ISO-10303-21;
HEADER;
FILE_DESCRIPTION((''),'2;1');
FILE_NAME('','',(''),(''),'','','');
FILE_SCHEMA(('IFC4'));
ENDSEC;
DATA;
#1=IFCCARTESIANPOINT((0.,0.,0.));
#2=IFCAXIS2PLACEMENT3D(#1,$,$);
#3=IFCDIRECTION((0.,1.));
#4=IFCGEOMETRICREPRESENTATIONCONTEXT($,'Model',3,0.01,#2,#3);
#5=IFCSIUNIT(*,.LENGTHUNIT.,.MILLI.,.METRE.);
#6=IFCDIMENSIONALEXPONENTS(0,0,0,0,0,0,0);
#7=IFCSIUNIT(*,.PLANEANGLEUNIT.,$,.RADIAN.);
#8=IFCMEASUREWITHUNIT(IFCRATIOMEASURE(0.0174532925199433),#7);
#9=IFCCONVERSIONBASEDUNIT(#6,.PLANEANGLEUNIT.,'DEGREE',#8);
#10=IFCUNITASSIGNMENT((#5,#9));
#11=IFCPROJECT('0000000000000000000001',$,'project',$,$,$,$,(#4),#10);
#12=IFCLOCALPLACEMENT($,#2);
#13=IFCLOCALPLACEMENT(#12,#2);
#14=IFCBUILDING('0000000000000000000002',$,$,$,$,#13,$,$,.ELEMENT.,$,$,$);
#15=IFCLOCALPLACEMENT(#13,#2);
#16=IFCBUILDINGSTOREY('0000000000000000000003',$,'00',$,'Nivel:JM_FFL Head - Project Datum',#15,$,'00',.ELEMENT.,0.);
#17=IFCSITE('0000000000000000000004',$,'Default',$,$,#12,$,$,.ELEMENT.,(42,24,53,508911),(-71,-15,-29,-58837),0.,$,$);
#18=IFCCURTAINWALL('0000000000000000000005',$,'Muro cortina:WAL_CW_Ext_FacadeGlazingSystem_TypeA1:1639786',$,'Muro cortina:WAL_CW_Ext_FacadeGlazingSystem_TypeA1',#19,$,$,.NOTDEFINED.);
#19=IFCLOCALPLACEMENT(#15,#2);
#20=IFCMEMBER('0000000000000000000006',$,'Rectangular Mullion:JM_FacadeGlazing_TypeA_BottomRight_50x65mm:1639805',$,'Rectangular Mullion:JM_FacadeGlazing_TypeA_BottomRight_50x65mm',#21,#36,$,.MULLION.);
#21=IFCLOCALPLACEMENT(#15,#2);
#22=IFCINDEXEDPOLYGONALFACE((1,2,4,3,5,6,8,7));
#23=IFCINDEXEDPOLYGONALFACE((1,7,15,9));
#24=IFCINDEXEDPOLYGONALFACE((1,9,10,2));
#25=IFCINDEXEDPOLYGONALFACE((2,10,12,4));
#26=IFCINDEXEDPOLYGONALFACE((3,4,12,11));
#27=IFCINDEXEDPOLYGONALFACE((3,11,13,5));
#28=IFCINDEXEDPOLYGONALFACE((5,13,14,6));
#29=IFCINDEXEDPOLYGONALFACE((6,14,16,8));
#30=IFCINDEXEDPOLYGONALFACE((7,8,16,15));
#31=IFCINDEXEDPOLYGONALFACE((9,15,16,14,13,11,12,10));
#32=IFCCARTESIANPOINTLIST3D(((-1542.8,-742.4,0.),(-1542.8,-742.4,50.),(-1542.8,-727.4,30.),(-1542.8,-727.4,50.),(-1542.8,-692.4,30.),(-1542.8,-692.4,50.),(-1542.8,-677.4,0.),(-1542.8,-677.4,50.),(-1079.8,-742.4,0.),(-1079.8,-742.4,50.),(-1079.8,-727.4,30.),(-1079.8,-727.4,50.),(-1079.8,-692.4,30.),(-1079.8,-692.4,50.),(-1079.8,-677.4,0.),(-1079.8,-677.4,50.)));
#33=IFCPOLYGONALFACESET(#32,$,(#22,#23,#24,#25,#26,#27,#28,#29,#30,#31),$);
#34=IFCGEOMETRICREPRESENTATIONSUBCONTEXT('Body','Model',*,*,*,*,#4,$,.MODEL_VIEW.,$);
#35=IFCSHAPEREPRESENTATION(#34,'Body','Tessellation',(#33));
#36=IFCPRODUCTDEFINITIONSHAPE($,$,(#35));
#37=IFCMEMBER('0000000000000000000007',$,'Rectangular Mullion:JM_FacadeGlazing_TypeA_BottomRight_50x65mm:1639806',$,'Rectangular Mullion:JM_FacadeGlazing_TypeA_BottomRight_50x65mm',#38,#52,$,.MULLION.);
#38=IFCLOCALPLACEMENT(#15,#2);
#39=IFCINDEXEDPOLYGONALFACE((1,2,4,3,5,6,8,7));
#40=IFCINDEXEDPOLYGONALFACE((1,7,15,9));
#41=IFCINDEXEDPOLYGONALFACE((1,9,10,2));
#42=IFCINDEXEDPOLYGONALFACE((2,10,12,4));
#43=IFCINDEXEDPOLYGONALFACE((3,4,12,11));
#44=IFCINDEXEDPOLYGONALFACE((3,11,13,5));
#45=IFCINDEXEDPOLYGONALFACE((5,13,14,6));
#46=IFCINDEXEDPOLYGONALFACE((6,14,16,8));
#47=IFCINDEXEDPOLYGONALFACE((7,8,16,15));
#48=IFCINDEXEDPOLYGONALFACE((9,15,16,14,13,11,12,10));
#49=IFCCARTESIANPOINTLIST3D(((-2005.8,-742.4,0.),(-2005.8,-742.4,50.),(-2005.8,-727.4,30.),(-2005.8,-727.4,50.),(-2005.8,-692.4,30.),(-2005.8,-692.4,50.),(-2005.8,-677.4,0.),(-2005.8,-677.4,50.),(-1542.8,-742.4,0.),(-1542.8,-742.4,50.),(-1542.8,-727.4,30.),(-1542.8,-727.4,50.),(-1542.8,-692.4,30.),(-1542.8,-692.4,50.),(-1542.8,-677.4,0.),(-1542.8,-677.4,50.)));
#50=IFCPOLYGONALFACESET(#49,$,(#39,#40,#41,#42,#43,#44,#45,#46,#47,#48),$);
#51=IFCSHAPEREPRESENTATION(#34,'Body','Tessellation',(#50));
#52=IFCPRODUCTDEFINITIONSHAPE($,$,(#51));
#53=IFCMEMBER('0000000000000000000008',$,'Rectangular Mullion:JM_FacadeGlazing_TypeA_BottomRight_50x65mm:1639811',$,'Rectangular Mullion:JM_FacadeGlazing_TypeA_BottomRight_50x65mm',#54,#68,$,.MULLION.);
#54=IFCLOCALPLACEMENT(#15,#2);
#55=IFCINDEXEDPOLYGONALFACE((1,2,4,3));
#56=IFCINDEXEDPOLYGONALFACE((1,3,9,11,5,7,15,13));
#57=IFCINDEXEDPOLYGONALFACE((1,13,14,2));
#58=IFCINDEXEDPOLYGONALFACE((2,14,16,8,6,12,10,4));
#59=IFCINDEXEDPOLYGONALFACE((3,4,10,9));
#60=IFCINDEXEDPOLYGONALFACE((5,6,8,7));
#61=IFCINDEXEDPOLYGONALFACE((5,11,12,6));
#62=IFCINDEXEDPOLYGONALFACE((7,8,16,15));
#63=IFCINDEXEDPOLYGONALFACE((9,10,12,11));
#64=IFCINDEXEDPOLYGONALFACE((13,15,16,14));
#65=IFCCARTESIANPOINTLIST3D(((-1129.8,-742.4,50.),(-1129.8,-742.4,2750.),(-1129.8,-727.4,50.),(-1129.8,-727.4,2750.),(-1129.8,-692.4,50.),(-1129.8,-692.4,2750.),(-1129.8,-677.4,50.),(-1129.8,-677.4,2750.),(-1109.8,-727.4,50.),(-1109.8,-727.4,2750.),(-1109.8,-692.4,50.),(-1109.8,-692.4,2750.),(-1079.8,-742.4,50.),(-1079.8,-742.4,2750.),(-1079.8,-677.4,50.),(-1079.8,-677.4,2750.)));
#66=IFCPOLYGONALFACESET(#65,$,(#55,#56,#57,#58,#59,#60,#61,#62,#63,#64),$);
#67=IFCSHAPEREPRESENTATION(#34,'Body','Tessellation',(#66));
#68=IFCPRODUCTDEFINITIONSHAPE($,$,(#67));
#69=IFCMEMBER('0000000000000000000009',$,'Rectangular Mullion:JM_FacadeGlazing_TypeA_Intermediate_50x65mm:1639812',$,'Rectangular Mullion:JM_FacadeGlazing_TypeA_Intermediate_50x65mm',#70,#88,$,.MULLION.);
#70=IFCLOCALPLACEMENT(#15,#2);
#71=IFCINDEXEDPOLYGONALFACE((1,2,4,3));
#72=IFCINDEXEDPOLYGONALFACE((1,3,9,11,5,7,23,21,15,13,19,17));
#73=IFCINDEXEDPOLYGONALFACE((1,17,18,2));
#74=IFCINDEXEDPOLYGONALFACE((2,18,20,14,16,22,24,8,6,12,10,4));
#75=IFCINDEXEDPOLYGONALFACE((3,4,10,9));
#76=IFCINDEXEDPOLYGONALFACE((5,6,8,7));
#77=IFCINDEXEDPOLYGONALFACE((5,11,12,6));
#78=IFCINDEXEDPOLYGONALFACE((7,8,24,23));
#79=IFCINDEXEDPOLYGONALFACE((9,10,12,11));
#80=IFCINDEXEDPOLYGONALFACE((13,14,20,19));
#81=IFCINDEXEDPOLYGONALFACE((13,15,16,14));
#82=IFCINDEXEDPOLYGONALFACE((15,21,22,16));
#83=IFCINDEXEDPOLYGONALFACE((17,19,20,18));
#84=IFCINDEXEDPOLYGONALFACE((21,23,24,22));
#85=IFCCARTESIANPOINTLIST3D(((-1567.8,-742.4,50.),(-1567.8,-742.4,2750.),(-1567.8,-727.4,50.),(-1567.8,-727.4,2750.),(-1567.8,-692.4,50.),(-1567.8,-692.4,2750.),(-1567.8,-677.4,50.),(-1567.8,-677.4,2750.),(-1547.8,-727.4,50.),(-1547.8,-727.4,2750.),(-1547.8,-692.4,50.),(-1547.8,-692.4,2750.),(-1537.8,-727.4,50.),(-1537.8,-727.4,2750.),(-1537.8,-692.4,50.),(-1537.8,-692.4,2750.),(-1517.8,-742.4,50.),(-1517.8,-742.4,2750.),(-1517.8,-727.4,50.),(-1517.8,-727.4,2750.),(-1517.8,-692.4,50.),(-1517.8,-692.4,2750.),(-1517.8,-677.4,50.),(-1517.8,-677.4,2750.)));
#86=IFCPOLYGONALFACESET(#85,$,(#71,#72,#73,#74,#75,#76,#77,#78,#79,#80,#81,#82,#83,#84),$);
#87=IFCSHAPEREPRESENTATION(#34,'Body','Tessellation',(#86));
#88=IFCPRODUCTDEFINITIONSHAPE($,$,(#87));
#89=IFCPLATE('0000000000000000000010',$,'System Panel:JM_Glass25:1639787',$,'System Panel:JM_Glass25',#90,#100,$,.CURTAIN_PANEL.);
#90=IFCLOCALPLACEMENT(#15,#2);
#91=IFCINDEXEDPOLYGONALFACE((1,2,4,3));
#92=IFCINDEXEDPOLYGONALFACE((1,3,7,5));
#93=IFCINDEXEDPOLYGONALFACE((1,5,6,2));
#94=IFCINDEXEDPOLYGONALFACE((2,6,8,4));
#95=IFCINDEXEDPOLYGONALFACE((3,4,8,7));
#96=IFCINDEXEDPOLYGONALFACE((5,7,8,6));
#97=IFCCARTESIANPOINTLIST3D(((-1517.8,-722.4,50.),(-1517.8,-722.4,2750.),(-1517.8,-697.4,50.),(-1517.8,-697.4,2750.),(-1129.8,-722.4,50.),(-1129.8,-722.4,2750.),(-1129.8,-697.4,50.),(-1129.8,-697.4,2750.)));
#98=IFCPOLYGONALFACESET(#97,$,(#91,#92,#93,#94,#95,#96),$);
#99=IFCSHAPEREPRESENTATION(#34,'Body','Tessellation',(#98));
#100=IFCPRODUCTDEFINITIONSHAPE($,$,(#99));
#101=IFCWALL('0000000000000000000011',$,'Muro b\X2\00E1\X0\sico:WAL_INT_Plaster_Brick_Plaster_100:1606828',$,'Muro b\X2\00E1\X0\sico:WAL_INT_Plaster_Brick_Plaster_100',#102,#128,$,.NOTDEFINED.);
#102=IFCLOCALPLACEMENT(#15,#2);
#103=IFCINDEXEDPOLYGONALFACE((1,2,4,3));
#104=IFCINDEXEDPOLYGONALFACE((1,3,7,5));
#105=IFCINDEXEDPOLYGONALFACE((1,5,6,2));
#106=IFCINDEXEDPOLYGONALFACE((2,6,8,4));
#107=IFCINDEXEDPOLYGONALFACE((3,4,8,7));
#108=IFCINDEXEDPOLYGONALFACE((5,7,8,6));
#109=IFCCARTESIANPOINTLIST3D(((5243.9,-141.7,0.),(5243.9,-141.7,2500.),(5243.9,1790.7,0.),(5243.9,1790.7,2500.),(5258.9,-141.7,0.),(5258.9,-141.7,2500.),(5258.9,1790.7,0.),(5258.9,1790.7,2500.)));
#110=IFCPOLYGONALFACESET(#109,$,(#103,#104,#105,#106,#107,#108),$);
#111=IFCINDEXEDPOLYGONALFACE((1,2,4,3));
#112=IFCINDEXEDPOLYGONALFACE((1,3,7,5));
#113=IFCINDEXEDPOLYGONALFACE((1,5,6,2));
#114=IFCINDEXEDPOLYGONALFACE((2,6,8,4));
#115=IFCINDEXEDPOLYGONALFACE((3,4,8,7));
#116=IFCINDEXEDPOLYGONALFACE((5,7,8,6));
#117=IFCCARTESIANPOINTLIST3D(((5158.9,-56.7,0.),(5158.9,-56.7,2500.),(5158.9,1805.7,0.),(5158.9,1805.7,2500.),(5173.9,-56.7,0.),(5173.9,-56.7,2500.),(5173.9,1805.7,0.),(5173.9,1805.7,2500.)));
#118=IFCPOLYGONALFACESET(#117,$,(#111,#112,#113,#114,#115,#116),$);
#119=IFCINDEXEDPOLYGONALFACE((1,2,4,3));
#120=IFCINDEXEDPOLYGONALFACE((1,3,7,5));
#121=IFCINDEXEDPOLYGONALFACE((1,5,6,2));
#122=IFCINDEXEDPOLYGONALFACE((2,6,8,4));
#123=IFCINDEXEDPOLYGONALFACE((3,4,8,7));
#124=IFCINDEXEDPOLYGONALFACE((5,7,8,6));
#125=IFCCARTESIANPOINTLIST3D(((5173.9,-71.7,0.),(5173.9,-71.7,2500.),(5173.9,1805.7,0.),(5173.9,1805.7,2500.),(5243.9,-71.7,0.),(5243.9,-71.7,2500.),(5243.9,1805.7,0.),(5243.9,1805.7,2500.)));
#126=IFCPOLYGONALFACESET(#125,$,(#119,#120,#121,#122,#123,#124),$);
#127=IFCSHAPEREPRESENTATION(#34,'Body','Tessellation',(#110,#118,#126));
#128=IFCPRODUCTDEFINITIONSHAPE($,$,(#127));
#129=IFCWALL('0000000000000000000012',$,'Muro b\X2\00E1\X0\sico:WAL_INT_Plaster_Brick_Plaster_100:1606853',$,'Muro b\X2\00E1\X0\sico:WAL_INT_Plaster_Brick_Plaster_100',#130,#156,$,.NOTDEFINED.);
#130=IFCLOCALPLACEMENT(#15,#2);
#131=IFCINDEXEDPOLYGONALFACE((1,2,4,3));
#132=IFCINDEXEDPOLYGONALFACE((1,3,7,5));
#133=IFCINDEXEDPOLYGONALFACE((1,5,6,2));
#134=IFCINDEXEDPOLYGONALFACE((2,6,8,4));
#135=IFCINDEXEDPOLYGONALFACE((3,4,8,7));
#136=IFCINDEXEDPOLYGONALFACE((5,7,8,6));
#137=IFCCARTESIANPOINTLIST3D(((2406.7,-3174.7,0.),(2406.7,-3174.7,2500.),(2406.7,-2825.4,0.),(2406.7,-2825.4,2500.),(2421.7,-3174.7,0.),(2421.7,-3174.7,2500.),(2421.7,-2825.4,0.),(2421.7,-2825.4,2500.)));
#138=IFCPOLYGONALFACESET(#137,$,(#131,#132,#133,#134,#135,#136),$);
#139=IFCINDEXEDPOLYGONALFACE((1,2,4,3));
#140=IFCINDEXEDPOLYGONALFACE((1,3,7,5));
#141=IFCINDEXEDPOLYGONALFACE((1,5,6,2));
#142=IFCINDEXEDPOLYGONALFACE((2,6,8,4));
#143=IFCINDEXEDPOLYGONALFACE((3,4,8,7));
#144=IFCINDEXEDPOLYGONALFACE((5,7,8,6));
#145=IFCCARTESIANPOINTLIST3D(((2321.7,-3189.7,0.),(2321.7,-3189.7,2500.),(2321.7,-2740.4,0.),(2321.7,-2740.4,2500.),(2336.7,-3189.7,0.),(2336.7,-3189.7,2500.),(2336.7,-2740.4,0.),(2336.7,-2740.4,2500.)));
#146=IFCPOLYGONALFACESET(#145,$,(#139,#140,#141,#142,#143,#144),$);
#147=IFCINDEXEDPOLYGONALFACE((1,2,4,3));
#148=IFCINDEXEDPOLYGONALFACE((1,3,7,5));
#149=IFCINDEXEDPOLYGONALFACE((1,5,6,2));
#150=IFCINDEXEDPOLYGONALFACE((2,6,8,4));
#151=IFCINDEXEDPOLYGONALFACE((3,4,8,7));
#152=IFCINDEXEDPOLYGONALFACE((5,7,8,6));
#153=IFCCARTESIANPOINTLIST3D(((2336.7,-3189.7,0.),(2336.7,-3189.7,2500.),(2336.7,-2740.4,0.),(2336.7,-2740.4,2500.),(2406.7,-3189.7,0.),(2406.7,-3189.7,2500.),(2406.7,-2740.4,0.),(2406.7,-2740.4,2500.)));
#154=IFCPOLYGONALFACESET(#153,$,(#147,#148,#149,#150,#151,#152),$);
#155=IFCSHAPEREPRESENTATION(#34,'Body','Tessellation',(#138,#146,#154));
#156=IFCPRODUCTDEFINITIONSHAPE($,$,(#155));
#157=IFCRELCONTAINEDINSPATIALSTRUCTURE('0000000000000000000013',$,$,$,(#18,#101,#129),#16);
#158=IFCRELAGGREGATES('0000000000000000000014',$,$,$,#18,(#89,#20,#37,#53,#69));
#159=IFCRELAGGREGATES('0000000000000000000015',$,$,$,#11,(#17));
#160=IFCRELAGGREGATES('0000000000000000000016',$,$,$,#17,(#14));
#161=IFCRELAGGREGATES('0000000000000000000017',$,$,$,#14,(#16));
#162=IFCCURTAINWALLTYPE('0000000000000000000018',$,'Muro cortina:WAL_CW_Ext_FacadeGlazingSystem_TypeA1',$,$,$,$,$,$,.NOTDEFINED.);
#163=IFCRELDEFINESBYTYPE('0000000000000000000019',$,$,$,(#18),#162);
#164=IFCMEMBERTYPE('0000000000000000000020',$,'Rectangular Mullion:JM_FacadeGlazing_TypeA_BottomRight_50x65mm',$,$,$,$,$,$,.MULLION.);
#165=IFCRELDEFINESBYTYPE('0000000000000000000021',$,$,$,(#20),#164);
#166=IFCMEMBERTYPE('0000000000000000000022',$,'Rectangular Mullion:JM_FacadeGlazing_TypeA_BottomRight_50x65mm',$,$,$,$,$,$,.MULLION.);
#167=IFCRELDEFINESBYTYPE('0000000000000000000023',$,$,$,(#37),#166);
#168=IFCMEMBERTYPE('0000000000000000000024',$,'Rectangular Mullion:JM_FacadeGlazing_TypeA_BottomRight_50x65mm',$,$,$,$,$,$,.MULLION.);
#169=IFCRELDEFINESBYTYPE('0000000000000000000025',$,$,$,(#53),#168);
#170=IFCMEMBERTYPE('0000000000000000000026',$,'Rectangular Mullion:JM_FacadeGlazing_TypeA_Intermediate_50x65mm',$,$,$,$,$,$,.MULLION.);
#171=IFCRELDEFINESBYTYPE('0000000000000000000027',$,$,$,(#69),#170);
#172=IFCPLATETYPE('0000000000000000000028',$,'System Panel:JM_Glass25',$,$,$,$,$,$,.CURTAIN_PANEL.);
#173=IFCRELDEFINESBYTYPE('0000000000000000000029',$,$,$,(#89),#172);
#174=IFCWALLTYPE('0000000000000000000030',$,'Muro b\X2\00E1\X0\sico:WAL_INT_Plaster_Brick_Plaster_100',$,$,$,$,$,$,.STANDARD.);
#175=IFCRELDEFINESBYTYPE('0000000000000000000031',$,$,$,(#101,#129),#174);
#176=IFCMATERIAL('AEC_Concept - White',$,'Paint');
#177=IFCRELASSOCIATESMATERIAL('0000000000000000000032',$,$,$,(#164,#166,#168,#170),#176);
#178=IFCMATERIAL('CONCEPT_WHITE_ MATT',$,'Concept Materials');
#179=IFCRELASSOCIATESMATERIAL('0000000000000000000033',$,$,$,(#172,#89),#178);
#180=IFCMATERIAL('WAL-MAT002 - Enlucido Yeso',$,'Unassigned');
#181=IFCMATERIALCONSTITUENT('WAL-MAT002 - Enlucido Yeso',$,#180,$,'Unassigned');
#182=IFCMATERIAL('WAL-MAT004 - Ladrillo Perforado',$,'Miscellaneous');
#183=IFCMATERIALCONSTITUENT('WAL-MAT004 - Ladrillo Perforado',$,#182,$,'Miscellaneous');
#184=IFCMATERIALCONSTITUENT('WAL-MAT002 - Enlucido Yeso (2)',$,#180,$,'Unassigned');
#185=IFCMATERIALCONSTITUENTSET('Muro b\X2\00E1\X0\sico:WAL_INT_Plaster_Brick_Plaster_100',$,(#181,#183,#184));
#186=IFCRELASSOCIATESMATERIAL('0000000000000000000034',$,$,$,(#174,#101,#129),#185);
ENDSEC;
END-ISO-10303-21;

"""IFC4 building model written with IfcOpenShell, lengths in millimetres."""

from ifc_helpers import new_model, entity, si_unit, converted_unit, direction, frame, origin, place, context, subcontext, project, spatial, indexed_curve, outline, extrude, source, transform, mapped, material, constituent, constituent_set, type_object, type_shapes, element, aggregate, save


model = new_model("IFC4")

# Units and contexts
model_context = context("Model", 3, precision=0.01, world=origin(), true_north=direction((0.0, 1.0)))
body_context = subcontext(model_context, "Body", "Model", "MODEL_VIEW")
ifc_project = project(units=[si_unit("LENGTHUNIT", "METRE", prefix="MILLI"), converted_unit("PLANEANGLEUNIT", "DEGREE", entity("IfcRatioMeasure", 0.0174532925199433), si_unit("PLANEANGLEUNIT", "RADIAN"), dimensions=[0, 0, 0, 0, 0, 0, 0])], contexts=[model_context])

# Site, building, storey
site_placement = place(None, origin())
site = spatial("IfcSite", under=ifc_project, at=site_placement, Name="Default", CompositionType="ELEMENT", RefLatitude=(42, 24, 53, 508911), RefLongitude=(-71, -15, -29, -58837), RefElevation=0.0)
building_placement = place(site_placement, origin())
building = spatial("IfcBuilding", under=site, at=building_placement, CompositionType="ELEMENT")
storey_placement = place(building_placement, origin())
storey = spatial("IfcBuildingStorey", under=building, at=storey_placement, Name="00", ObjectType="Nivel:JM_FFL Head - Project Datum", LongName="00", CompositionType="ELEMENT", Elevation=0.0)

# Curtain wall, members
curtain_wall_type = type_object("IfcCurtainWallType", Name="Muro cortina:WAL_CW_Ext_FacadeGlazingSystem_TypeA1", PredefinedType="NOTDEFINED")
curtain_wall_placement = place(storey_placement, origin())
curtain_wall = element("IfcCurtainWall", 1, at=curtain_wall_placement, inside=storey, type_object=curtain_wall_type, Name="Muro cortina:WAL_CW_Ext_FacadeGlazingSystem_TypeA1:1639786", ObjectType="Muro cortina:WAL_CW_Ext_FacadeGlazingSystem_TypeA1", PredefinedType="NOTDEFINED")
ifc_material_1 = material(Name="AEC_Concept - White", Category="Paint")
member_type_1 = type_object("IfcMemberType", Name="Rectangular Mullion:JM_FacadeGlazing_TypeA_BottomRight_50x65mm", PredefinedType="MULLION", material=ifc_material_1)
shared_shape_1 = source(origin(), body_context, "Body", "SweptSolid", [
    extrude(outline(indexed_curve([(-32.5, -17.5), (-17.5, -17.5), (-17.5, 2.5), (17.5, 2.5), (17.5, -17.5), (32.5, -17.5), (32.5, 32.5), (-32.5, 32.5), (-32.5, -17.5)], self_intersect=False)), frame((-32.5, -32.5, -463.0), z_axis=(0.0, 0.0, 1.0), x_axis=(0.0, -1.0, 0.0)), (0.0, 0.0, 1.0), 463.0),
])
type_shapes(member_type_1, [shared_shape_1])
member_1_placement = place(curtain_wall_placement, frame((-1079.8, -677.4, 0.0), z_axis=(1.0, 0.0, 0.0), x_axis=(0.0, 0.0, -1.0)))
member_1 = element("IfcMember", 2, at=member_1_placement, type_object=member_type_1, Name="Rectangular Mullion:JM_FacadeGlazing_TypeA_BottomRight_50x65mm:1639805", ObjectType="Rectangular Mullion:JM_FacadeGlazing_TypeA_BottomRight_50x65mm", PredefinedType="MULLION", context=body_context, shape_type="MappedRepresentation", body=[
    mapped(shared_shape_1, transform((0.0, 0.0, 0.0), scale=1.0)),
])
member_type_2 = type_object("IfcMemberType", Name="Rectangular Mullion:JM_FacadeGlazing_TypeA_BottomRight_50x65mm", PredefinedType="MULLION", material=ifc_material_1)
shared_shape_2 = source(origin(), body_context, "Body", "SweptSolid", [
    extrude(outline(indexed_curve([(-32.5, -17.5), (-17.5, -17.5), (-17.5, 2.5), (17.5, 2.5), (17.5, -17.5), (32.5, -17.5), (32.5, 32.5), (-32.5, 32.5), (-32.5, -17.5)], self_intersect=False)), frame((-32.5, -32.5, -463.0), z_axis=(0.0, 0.0, 1.0), x_axis=(0.0, -1.0, 0.0)), (0.0, 0.0, 1.0), 463.0),
])
type_shapes(member_type_2, [shared_shape_2])
member_2_placement = place(curtain_wall_placement, frame((-1542.8, -677.4, 0.0), z_axis=(1.0, 0.0, 0.0), x_axis=(0.0, 0.0, -1.0)))
member_2 = element("IfcMember", 3, at=member_2_placement, type_object=member_type_2, Name="Rectangular Mullion:JM_FacadeGlazing_TypeA_BottomRight_50x65mm:1639806", ObjectType="Rectangular Mullion:JM_FacadeGlazing_TypeA_BottomRight_50x65mm", PredefinedType="MULLION", context=body_context, shape_type="MappedRepresentation", body=[
    mapped(shared_shape_2, transform((0.0, 0.0, 0.0), scale=1.0)),
])
member_type_3 = type_object("IfcMemberType", Name="Rectangular Mullion:JM_FacadeGlazing_TypeA_BottomRight_50x65mm", PredefinedType="MULLION", material=ifc_material_1)
shared_shape_3 = source(origin(), body_context, "Body", "SweptSolid", [
    extrude(outline(indexed_curve([(-32.5, -17.5), (-17.5, -17.5), (-17.5, 2.5), (17.5, 2.5), (17.5, -17.5), (32.5, -17.5), (32.5, 32.5), (-32.5, 32.5), (-32.5, -17.5)], self_intersect=False)), frame((-32.5, -32.5, -2700.0), z_axis=(0.0, 0.0, 1.0), x_axis=(0.0, -1.0, 0.0)), (0.0, 0.0, 1.0), 2700.0),
])
type_shapes(member_type_3, [shared_shape_3])
member_3_placement = place(curtain_wall_placement, frame((-1079.8, -677.4, 2750.0)))
member_3 = element("IfcMember", 4, at=member_3_placement, type_object=member_type_3, Name="Rectangular Mullion:JM_FacadeGlazing_TypeA_BottomRight_50x65mm:1639811", ObjectType="Rectangular Mullion:JM_FacadeGlazing_TypeA_BottomRight_50x65mm", PredefinedType="MULLION", context=body_context, shape_type="MappedRepresentation", body=[
    mapped(shared_shape_3, transform((0.0, 0.0, 0.0), scale=1.0)),
])
member_type_4 = type_object("IfcMemberType", Name="Rectangular Mullion:JM_FacadeGlazing_TypeA_Intermediate_50x65mm", PredefinedType="MULLION", material=ifc_material_1)
shared_shape_4 = source(origin(), body_context, "Body", "SweptSolid", [
    extrude(outline(indexed_curve([(-32.5, -25.0), (-17.5, -25.0), (-17.5, -5.0), (17.5, -5.0), (17.5, -25.0), (32.5, -25.0), (32.5, 25.0), (17.5, 25.0), (17.5, 5.0), (-17.5, 5.0), (-17.5, 25.0), (-32.5, 25.0), (-32.5, -25.0)], self_intersect=False)), frame((0.0, -32.5, -2700.0), z_axis=(0.0, 0.0, 1.0), x_axis=(0.0, -1.0, 0.0)), (0.0, 0.0, 1.0), 2700.0),
])
type_shapes(member_type_4, [shared_shape_4])
member_4_placement = place(curtain_wall_placement, frame((-1542.8, -677.4, 50.0), z_axis=(0.0, 0.0, -1.0), x_axis=(-1.0, 0.0, 0.0)))
member_4 = element("IfcMember", 5, at=member_4_placement, type_object=member_type_4, Name="Rectangular Mullion:JM_FacadeGlazing_TypeA_Intermediate_50x65mm:1639812", ObjectType="Rectangular Mullion:JM_FacadeGlazing_TypeA_Intermediate_50x65mm", PredefinedType="MULLION", context=body_context, shape_type="MappedRepresentation", body=[
    mapped(shared_shape_4, transform((0.0, 0.0, 0.0), scale=1.0)),
])

# Shared definitions
ifc_material_2 = material(Name="CONCEPT_WHITE_ MATT", Category="Concept Materials")

# Plate
plate_type = type_object("IfcPlateType", Name="System Panel:JM_Glass25", PredefinedType="CURTAIN_PANEL", material=ifc_material_2)
shared_shape_5 = source(origin(), body_context, "Body", "SweptSolid", [
    extrude(outline(indexed_curve([(-12.5, -194.0), (12.5, -194.0), (12.5, 194.0), (-12.5, 194.0), (-12.5, -194.0)], self_intersect=False)), frame((0.0, 32.5, 0.0), z_axis=(0.0, 0.0, 1.0), x_axis=(0.0, 1.0, 0.0)), (0.0, 0.0, 1.0), 2700.0),
])
type_shapes(plate_type, [shared_shape_5])
plate_placement = place(curtain_wall_placement, frame((-1323.8, -677.4, 50.0), z_axis=(0.0, 0.0, 1.0), x_axis=(-1.0, 0.0, 0.0)))
plate = element("IfcPlate", 6, at=plate_placement, type_object=plate_type, material=ifc_material_2, Name="System Panel:JM_Glass25:1639787", ObjectType="System Panel:JM_Glass25", PredefinedType="CURTAIN_PANEL", context=body_context, shape_type="MappedRepresentation", body=[
    mapped(shared_shape_5, transform((0.0, 0.0, 0.0), scale=1.0)),
])
aggregate(curtain_wall, [plate, member_1, member_2, member_3, member_4])

# Walls
ifc_material_3 = material(Name="WAL-MAT004 - Ladrillo Perforado", Category="Miscellaneous")
ifc_material_4 = material(Name="WAL-MAT002 - Enlucido Yeso", Category="Unassigned")
ifc_constituent_1 = constituent(ifc_material_4, Name="WAL-MAT002 - Enlucido Yeso", Category="Unassigned")
ifc_constituent_2 = constituent(ifc_material_3, Name="WAL-MAT004 - Ladrillo Perforado", Category="Miscellaneous")
ifc_constituent_3 = constituent(ifc_material_4, Name="WAL-MAT002 - Enlucido Yeso (2)", Category="Unassigned")
ifc_constituent_set_1 = constituent_set(constituents=[ifc_constituent_1, ifc_constituent_2, ifc_constituent_3], Name="Muro básico:WAL_INT_Plaster_Brick_Plaster_100")
wall_type_1 = type_object("IfcWallType", Name="Muro básico:WAL_INT_Plaster_Brick_Plaster_100", PredefinedType="STANDARD", material=ifc_constituent_set_1)
wall_1_placement = place(storey_placement, frame((5208.9, -56.7, 0.0), z_axis=(0.0, 0.0, 1.0), x_axis=(0.0, 1.0, 0.0)))
element("IfcWall", 7, at=wall_1_placement, inside=storey, type_object=wall_type_1, material=ifc_constituent_set_1, Name="Muro básico:WAL_INT_Plaster_Brick_Plaster_100:1606828", ObjectType="Muro básico:WAL_INT_Plaster_Brick_Plaster_100", PredefinedType="NOTDEFINED", context=body_context, shape_type="SweptSolid", body=[
    extrude(outline(indexed_curve([(-7.5, -966.2), (7.5, -966.2), (7.5, 966.2), (-7.5, 966.2), (-7.5, -966.2)], self_intersect=False)), frame((881.2, -42.5, 0.0), z_axis=(0.0, 0.0, 1.0), x_axis=(0.0, 1.0, 0.0)), (0.0, 0.0, 1.0), 2500.0),
    extrude(outline(indexed_curve([(-7.5, -931.2), (7.5, -931.2), (7.5, 931.2), (-7.5, 931.2), (-7.5, -931.2)], self_intersect=False)), frame((931.2, 42.5, 0.0), z_axis=(0.0, 0.0, 1.0), x_axis=(0.0, -1.0, 0.0)), (0.0, 0.0, 1.0), 2500.0),
    extrude(outline(indexed_curve([(-938.7, -35.0), (938.7, -35.0), (938.7, 35.0), (-938.7, 35.0), (-938.7, -35.0)], self_intersect=False)), frame((923.7, 0.0, 0.0)), (0.0, 0.0, 1.0), 2500.0),
])
wall_2_placement = place(storey_placement, frame((2371.7, -3174.7, 0.0), z_axis=(0.0, 0.0, 1.0), x_axis=(0.0, 1.0, 0.0)))
element("IfcWall", 8, at=wall_2_placement, inside=storey, type_object=wall_type_1, material=ifc_constituent_set_1, Name="Muro básico:WAL_INT_Plaster_Brick_Plaster_100:1606853", ObjectType="Muro básico:WAL_INT_Plaster_Brick_Plaster_100", PredefinedType="NOTDEFINED", context=body_context, shape_type="SweptSolid", body=[
    extrude(outline(indexed_curve([(-7.5, -174.6), (7.5, -174.6), (7.5, 174.6), (-7.5, 174.6), (-7.5, -174.6)], self_intersect=False)), frame((174.6, -42.5, 0.0), z_axis=(0.0, 0.0, 1.0), x_axis=(0.0, 1.0, 0.0)), (0.0, 0.0, 1.0), 2500.0),
    extrude(outline(indexed_curve([(-7.5, -224.6), (7.5, -224.6), (7.5, 224.6), (-7.5, 224.6), (-7.5, -224.6)], self_intersect=False)), frame((209.6, 42.5, 0.0), z_axis=(0.0, 0.0, 1.0), x_axis=(0.0, -1.0, 0.0)), (0.0, 0.0, 1.0), 2500.0),
    extrude(outline(indexed_curve([(-224.6, -35.0), (224.6, -35.0), (224.6, 35.0), (-224.6, 35.0), (-224.6, -35.0)], self_intersect=False)), frame((209.6, 0.0, 0.0)), (0.0, 0.0, 1.0), 2500.0),
])

save(model, "model.ifc")
